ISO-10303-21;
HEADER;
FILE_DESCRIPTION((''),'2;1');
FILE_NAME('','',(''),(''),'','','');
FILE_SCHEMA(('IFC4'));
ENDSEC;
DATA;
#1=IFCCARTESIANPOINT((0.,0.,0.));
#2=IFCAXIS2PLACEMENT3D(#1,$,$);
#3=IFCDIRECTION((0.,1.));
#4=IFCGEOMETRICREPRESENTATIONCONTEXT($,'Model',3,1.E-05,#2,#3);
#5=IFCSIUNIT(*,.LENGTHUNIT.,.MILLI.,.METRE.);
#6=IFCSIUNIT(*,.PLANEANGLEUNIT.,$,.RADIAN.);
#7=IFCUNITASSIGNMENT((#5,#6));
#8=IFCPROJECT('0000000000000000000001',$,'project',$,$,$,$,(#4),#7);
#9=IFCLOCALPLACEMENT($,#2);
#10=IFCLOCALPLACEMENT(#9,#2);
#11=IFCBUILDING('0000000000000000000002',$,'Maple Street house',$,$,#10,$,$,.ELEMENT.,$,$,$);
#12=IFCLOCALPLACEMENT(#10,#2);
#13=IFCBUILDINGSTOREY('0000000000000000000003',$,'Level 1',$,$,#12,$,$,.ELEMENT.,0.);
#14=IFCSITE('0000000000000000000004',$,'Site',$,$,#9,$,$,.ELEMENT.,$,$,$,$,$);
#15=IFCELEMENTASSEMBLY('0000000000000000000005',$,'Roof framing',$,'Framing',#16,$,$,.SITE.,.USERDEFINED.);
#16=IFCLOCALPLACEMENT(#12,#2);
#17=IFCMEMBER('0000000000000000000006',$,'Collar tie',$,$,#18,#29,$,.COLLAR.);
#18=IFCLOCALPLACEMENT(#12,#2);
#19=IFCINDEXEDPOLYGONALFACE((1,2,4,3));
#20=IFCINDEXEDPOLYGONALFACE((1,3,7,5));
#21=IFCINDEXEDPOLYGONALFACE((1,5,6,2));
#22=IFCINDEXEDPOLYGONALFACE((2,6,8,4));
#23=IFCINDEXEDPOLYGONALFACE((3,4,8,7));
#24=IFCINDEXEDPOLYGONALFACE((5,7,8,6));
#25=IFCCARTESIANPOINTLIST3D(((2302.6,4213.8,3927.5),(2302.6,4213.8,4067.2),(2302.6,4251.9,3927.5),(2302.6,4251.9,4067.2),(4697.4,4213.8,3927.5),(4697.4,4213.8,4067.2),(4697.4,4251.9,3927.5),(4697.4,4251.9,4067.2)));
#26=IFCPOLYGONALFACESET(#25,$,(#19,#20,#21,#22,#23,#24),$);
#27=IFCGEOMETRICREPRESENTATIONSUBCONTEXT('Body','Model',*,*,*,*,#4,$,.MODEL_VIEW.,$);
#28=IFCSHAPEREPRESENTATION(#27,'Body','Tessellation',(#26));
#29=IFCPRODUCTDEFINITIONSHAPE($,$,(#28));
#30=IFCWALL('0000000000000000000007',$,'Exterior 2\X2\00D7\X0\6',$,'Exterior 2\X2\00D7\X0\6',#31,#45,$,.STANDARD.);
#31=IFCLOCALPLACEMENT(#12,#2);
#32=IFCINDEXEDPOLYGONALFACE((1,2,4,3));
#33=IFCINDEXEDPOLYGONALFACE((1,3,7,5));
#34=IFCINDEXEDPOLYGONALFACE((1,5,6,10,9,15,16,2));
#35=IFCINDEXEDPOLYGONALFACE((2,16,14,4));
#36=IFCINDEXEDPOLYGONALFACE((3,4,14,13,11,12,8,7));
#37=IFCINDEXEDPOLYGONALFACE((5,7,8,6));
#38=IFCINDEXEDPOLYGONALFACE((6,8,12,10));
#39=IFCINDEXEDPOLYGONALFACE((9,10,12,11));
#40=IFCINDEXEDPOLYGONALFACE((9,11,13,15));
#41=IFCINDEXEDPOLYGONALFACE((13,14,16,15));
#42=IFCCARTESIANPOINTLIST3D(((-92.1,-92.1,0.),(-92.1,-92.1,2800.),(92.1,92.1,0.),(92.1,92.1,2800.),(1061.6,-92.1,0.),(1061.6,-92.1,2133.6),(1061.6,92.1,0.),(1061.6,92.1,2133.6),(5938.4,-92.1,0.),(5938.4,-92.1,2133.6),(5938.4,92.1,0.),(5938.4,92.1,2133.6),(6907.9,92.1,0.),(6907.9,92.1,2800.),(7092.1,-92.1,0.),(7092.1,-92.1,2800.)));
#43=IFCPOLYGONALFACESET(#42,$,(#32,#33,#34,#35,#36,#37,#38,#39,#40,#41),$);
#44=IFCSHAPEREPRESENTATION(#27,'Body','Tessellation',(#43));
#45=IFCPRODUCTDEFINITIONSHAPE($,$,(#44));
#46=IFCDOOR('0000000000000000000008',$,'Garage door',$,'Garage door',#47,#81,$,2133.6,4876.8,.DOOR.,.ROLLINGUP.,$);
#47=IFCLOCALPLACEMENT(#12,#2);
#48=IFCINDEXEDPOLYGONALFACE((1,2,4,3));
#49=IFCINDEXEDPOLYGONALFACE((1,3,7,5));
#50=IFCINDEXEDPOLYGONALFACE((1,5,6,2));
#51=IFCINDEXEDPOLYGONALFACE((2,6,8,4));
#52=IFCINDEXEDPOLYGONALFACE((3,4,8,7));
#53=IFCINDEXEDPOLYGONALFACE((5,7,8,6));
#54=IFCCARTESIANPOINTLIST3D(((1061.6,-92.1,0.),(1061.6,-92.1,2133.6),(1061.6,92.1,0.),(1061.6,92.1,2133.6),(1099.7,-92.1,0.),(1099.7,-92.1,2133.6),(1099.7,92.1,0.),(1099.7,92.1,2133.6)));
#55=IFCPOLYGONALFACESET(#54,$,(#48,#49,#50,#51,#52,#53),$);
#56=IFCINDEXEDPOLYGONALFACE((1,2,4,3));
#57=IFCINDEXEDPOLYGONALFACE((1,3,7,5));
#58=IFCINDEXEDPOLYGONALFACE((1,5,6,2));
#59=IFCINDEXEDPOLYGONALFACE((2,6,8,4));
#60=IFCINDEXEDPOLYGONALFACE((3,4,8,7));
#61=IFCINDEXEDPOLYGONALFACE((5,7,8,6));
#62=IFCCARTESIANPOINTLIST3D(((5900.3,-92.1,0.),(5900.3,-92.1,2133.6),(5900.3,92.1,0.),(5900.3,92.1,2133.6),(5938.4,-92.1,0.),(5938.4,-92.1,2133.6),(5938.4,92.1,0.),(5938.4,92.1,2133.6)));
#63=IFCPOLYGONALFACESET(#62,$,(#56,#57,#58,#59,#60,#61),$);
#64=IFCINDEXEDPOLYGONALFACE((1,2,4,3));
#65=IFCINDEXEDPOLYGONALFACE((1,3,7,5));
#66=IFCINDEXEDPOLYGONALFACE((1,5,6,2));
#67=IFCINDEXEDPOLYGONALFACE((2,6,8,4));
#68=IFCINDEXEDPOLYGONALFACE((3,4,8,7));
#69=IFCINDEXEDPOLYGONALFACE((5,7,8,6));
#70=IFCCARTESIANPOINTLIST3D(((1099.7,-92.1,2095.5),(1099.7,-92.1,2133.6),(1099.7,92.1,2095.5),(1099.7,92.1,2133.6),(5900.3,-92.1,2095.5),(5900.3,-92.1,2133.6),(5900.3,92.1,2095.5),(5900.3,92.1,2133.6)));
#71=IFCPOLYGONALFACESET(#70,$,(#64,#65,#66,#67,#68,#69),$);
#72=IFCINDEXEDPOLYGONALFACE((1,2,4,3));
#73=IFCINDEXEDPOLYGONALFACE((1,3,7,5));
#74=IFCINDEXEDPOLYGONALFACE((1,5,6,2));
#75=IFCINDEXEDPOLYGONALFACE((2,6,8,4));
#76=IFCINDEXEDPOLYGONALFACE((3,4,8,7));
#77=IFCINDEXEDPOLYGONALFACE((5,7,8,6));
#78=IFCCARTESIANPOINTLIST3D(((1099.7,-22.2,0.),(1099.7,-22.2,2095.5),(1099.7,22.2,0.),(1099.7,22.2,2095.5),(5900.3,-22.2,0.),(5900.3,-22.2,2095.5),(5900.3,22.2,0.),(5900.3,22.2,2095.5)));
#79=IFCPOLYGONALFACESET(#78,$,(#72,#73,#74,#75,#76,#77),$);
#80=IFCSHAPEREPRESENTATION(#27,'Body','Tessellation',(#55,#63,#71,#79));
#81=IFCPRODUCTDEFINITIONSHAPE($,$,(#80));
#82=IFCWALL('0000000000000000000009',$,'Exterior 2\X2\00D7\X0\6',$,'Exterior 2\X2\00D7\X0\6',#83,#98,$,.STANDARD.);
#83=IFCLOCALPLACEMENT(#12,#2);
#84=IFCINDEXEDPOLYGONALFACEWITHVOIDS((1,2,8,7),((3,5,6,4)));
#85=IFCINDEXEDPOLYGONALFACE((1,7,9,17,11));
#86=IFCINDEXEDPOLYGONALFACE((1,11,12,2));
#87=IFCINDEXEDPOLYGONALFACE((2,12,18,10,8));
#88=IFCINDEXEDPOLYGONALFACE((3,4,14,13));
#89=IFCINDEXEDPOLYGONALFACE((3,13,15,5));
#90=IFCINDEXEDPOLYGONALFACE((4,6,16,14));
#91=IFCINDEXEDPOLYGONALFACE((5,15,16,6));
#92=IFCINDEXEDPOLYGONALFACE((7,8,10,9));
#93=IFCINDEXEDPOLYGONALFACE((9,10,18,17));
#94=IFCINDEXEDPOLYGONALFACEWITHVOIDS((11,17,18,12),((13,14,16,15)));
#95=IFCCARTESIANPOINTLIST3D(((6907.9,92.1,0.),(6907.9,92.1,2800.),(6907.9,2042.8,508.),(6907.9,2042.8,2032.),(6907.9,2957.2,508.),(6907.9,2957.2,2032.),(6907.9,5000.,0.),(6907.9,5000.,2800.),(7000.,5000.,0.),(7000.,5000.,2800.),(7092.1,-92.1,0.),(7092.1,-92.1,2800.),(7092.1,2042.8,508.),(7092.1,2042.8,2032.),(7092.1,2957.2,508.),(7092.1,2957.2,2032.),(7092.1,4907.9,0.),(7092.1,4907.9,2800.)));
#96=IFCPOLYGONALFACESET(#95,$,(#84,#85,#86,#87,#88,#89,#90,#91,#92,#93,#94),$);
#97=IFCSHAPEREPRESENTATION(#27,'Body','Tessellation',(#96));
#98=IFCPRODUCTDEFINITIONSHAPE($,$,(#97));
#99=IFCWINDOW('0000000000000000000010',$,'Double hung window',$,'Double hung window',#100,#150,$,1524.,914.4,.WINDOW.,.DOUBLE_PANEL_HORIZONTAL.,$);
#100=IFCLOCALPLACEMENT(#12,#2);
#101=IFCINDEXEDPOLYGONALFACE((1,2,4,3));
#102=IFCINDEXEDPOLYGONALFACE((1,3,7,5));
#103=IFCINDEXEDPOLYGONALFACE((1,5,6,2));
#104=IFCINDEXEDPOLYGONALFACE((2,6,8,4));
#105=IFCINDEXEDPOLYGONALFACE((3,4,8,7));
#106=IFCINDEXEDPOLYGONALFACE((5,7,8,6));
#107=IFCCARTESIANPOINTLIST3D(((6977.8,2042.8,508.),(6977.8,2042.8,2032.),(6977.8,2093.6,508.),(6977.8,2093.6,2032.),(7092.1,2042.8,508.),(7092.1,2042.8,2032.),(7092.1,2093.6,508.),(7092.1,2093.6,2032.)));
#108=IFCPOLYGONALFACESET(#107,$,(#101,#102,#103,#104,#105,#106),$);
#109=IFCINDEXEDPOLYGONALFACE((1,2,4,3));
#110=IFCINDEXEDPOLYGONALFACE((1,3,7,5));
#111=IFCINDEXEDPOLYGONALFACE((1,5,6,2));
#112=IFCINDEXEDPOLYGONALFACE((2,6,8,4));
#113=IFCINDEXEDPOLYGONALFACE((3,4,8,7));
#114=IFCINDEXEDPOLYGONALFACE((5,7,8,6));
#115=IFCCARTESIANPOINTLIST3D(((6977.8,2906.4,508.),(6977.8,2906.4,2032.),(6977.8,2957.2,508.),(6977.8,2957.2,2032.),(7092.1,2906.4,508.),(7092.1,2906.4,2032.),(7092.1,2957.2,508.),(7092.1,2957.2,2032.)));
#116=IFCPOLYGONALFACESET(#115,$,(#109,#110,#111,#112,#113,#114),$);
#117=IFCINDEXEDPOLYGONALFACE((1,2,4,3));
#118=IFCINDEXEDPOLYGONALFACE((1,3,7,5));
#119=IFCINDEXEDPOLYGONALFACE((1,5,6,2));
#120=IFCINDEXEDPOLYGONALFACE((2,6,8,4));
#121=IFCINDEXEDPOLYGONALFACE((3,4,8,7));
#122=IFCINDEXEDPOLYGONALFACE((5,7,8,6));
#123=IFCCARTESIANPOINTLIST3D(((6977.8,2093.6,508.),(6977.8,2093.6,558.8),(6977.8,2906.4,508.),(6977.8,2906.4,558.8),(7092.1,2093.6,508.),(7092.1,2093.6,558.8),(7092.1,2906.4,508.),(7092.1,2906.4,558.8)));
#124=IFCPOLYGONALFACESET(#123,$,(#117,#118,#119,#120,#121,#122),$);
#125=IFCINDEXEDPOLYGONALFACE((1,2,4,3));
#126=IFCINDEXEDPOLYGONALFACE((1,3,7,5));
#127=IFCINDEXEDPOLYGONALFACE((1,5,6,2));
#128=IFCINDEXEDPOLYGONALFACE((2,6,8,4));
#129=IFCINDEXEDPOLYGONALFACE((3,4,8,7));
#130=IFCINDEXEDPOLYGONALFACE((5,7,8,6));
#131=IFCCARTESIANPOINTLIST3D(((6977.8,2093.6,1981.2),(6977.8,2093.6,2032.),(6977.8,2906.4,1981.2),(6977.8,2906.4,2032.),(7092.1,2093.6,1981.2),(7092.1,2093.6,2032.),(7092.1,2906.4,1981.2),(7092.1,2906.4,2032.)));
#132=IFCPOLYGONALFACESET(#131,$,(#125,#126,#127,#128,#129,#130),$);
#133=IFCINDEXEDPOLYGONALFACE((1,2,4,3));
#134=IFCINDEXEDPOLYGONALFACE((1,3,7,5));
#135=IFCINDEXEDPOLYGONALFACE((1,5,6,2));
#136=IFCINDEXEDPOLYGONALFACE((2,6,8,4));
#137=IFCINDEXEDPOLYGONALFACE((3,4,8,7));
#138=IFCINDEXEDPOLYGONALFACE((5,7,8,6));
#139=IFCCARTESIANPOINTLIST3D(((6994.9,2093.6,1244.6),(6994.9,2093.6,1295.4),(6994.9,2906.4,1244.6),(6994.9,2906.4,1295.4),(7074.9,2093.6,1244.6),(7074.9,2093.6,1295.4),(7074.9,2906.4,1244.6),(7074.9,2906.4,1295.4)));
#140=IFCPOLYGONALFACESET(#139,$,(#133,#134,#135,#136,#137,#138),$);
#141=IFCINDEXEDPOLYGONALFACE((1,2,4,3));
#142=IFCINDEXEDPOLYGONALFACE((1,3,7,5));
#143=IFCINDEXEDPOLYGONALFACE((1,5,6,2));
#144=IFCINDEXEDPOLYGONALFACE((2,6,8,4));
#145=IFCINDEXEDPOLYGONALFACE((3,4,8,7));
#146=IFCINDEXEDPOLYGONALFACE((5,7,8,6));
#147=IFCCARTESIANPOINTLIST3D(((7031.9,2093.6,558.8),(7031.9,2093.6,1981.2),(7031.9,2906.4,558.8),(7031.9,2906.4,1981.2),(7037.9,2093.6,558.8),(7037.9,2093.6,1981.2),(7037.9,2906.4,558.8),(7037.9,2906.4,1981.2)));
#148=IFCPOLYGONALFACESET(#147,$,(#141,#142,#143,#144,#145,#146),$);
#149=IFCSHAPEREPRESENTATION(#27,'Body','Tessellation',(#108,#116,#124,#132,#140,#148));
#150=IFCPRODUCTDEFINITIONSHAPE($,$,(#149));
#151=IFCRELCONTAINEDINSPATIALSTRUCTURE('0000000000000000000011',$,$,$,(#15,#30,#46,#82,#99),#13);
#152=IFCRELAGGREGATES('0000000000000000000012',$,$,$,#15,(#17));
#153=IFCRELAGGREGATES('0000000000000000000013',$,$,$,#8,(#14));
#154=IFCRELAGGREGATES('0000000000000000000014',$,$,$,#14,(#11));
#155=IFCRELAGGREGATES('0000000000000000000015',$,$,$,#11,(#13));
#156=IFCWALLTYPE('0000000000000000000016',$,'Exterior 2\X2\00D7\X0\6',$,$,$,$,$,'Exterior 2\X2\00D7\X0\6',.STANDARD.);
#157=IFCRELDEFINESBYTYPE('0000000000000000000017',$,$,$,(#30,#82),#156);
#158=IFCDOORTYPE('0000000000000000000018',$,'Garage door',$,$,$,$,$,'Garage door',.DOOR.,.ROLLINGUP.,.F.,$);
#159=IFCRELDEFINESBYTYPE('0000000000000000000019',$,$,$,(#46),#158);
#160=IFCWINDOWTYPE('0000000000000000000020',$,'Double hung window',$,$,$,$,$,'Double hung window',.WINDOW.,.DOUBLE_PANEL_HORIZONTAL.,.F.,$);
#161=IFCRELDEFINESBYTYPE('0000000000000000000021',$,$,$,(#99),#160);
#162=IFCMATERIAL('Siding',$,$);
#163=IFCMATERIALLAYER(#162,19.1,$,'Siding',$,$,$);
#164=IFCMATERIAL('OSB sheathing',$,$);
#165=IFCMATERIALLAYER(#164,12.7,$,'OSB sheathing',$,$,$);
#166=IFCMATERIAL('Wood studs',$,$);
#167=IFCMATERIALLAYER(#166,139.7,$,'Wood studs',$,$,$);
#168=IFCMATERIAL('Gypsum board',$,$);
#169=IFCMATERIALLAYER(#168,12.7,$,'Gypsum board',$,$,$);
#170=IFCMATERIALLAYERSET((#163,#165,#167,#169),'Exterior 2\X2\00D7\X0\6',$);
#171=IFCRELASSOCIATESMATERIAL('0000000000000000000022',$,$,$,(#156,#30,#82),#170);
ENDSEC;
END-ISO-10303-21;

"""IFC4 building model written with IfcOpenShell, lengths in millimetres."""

from ifc_helpers import new_model, si_unit, direction, frame, origin, origin_with_axes, place, context, subcontext, project, spatial, polyline, outline, extrude, material, layer, layer_set, layer_usage, type_object, element, fill, aggregate, save


model = new_model("IFC4")

# Units and contexts
model_context = context("Model", 3, precision=1e-05, world=origin(), true_north=direction((0.0, 1.0)))
body_context = subcontext(model_context, "Body", "Model", "MODEL_VIEW")
ifc_project = project(units=[si_unit("LENGTHUNIT", "METRE", prefix="MILLI"), si_unit("PLANEANGLEUNIT", "RADIAN")], contexts=[model_context])

# Site, building, storey
site_placement = place(None, origin())
site = spatial("IfcSite", under=ifc_project, at=site_placement, Name="Site", CompositionType="ELEMENT")
building_placement = place(site_placement, origin())
building = spatial("IfcBuilding", under=site, at=building_placement, Name="Maple Street house", CompositionType="ELEMENT")
storey_placement = place(building_placement, origin())
storey = spatial("IfcBuildingStorey", under=building, at=storey_placement, Name="Level 1", CompositionType="ELEMENT", Elevation=0.0)

# Element assembly, member
assembly_placement = place(storey_placement, origin_with_axes())
assembly = element("IfcElementAssembly", 1, at=assembly_placement, inside=storey, Name="Roof framing", ObjectType="Framing", AssemblyPlace="SITE", PredefinedType="USERDEFINED")
member_placement = place(storey_placement, origin_with_axes())
member = element("IfcMember", 2, at=member_placement, Name="Collar tie", PredefinedType="COLLAR", context=body_context, shape_type="SweptSolid", body=[
    extrude(outline(polyline([(0.0, 0.0), (38.1, 0.0), (38.1, 139.7), (0.0, 139.7), (0.0, 0.0)])), frame((2302.6, 4213.8, 3927.5), z_axis=(1.0, 0.0, 0.0), x_axis=(0.0, 1.0, 0.0)), (0.0, 0.0, 1.0), 2394.7),
])
aggregate(assembly, [member])

# Wall, opening, door
ifc_material_1 = material(Name="Siding")
ifc_layer_1 = layer(ifc_material_1, 19.1, Name="Siding")
ifc_material_2 = material(Name="OSB sheathing")
ifc_layer_2 = layer(ifc_material_2, 12.7, Name="OSB sheathing")
ifc_material_3 = material(Name="Wood studs")
ifc_layer_3 = layer(ifc_material_3, 139.7, Name="Wood studs")
ifc_material_4 = material(Name="Gypsum board")
ifc_layer_4 = layer(ifc_material_4, 12.7, Name="Gypsum board")
ifc_layer_set_1 = layer_set([ifc_layer_1, ifc_layer_2, ifc_layer_3, ifc_layer_4], Name="Exterior 2×6")
ifc_layer_usage_1 = layer_usage(ifc_layer_set_1, "AXIS2", "POSITIVE", -92.1)
wall_type_1 = type_object("IfcWallType", Name="Exterior 2×6", ElementType="Exterior 2×6", PredefinedType="STANDARD", material=ifc_layer_set_1)
wall_1_placement = place(storey_placement, frame((0.0, 0.0, 0.0), z_axis=(0.0, 0.0, 1.0), x_axis=(1.0, 0.0, 0.0)))
wall_1 = element("IfcWall", 3, at=wall_1_placement, inside=storey, type_object=wall_type_1, material=ifc_layer_usage_1, Name="Exterior 2×6", ObjectType="Exterior 2×6", PredefinedType="STANDARD", context=body_context, shape_type="SweptSolid", body=[
    extrude(outline(polyline([(-92.1, -92.1), (7092.1, -92.1), (6907.9, 92.1), (92.1, 92.1), (-92.1, -92.1)])), origin(), (0.0, 0.0, 1.0), 2800.0),
])
opening_1_placement = place(wall_1_placement, frame((1061.6, 0.0, 0.0), z_axis=(0.0, 0.0, 1.0), x_axis=(1.0, 0.0, 0.0)))
opening_1 = element("IfcOpeningElement", 4, at=opening_1_placement, cuts=wall_1, PredefinedType="OPENING", context=body_context, shape_type="SweptSolid", body=[
    extrude(outline(polyline([(0.0, -102.1), (4876.8, -102.1), (4876.8, 102.1), (0.0, 102.1), (0.0, -102.1)])), origin(), (0.0, 0.0, 1.0), 2133.6),
])
door_type_1 = type_object("IfcDoorType", Name="Garage door", ElementType="Garage door", OperationType="ROLLINGUP", ParameterTakesPrecedence=False, PredefinedType="DOOR")
door_1_placement = place(opening_1_placement, origin_with_axes())
door_1 = element("IfcDoor", 5, at=door_1_placement, inside=storey, type_object=door_type_1, Name="Garage door", ObjectType="Garage door", OperationType="ROLLINGUP", OverallHeight=2133.6, OverallWidth=4876.8, PredefinedType="DOOR", context=body_context, shape_type="SweptSolid", body=[
    extrude(outline(polyline([(0.0, -92.1), (38.1, -92.1), (38.1, 92.1), (0.0, 92.1), (0.0, -92.1)])), origin(), (0.0, 0.0, 1.0), 2133.6),
    extrude(outline(polyline([(4838.7, -92.1), (4876.8, -92.1), (4876.8, 92.1), (4838.7, 92.1), (4838.7, -92.1)])), origin(), (0.0, 0.0, 1.0), 2133.6),
    extrude(outline(polyline([(38.1, -92.1), (4838.7, -92.1), (4838.7, 92.1), (38.1, 92.1), (38.1, -92.1)])), frame((0.0, 0.0, 2095.5)), (0.0, 0.0, 1.0), 38.1),
    extrude(outline(polyline([(38.1, -22.2), (4838.7, -22.2), (4838.7, 22.2), (38.1, 22.2), (38.1, -22.2)])), origin(), (0.0, 0.0, 1.0), 2095.5),
])
fill(opening_1, door_1)

# Wall, opening, window
ifc_layer_usage_2 = layer_usage(ifc_layer_set_1, "AXIS2", "POSITIVE", -92.1)
wall_2_placement = place(storey_placement, frame((7000.0, 0.0, 0.0), z_axis=(0.0, 0.0, 1.0), x_axis=(0.0, 1.0, 0.0)))
wall_2 = element("IfcWall", 6, at=wall_2_placement, inside=storey, type_object=wall_type_1, material=ifc_layer_usage_2, Name="Exterior 2×6", ObjectType="Exterior 2×6", PredefinedType="STANDARD", context=body_context, shape_type="SweptSolid", body=[
    extrude(outline(polyline([(-92.1, -92.1), (4907.9, -92.1), (5000.0, 0.0), (5000.0, 92.1), (92.1, 92.1), (-92.1, -92.1)])), origin(), (0.0, 0.0, 1.0), 2800.0),
])
opening_2_placement = place(wall_2_placement, frame((2042.8, 0.0, 508.0), z_axis=(0.0, 0.0, 1.0), x_axis=(1.0, 0.0, 0.0)))
opening_2 = element("IfcOpeningElement", 7, at=opening_2_placement, cuts=wall_2, PredefinedType="OPENING", context=body_context, shape_type="SweptSolid", body=[
    extrude(outline(polyline([(0.0, -102.1), (914.4, -102.1), (914.4, 102.1), (0.0, 102.1), (0.0, -102.1)])), origin(), (0.0, 0.0, 1.0), 1524.0),
])
window_type_1 = type_object("IfcWindowType", Name="Double hung window", ElementType="Double hung window", ParameterTakesPrecedence=False, PartitioningType="DOUBLE_PANEL_HORIZONTAL", PredefinedType="WINDOW")
window_1_placement = place(opening_2_placement, origin_with_axes())
window_1 = element("IfcWindow", 8, at=window_1_placement, inside=storey, type_object=window_type_1, Name="Double hung window", ObjectType="Double hung window", OverallHeight=1524.0, OverallWidth=914.4, PartitioningType="DOUBLE_PANEL_HORIZONTAL", PredefinedType="WINDOW", context=body_context, shape_type="SweptSolid", body=[
    extrude(outline(polyline([(0.0, -92.1), (50.8, -92.1), (50.8, 22.2), (0.0, 22.2), (0.0, -92.1)])), origin(), (0.0, 0.0, 1.0), 1524.0),
    extrude(outline(polyline([(863.6, -92.1), (914.4, -92.1), (914.4, 22.2), (863.6, 22.2), (863.6, -92.1)])), origin(), (0.0, 0.0, 1.0), 1524.0),
    extrude(outline(polyline([(50.8, -92.1), (863.6, -92.1), (863.6, 22.2), (50.8, 22.2), (50.8, -92.1)])), origin(), (0.0, 0.0, 1.0), 50.8),
    extrude(outline(polyline([(50.8, -92.1), (863.6, -92.1), (863.6, 22.2), (50.8, 22.2), (50.8, -92.1)])), frame((0.0, 0.0, 1473.2)), (0.0, 0.0, 1.0), 50.8),
    extrude(outline(polyline([(50.8, -74.9), (863.6, -74.9), (863.6, 5.1), (50.8, 5.1), (50.8, -74.9)])), frame((0.0, 0.0, 736.6)), (0.0, 0.0, 1.0), 50.8),
    extrude(outline(polyline([(50.8, -37.9), (863.6, -37.9), (863.6, -31.9), (50.8, -31.9), (50.8, -37.9)])), frame((0.0, 0.0, 50.8)), (0.0, 0.0, 1.0), 1422.4),
])
fill(opening_2, window_1)

save(model, "model.ifc")
